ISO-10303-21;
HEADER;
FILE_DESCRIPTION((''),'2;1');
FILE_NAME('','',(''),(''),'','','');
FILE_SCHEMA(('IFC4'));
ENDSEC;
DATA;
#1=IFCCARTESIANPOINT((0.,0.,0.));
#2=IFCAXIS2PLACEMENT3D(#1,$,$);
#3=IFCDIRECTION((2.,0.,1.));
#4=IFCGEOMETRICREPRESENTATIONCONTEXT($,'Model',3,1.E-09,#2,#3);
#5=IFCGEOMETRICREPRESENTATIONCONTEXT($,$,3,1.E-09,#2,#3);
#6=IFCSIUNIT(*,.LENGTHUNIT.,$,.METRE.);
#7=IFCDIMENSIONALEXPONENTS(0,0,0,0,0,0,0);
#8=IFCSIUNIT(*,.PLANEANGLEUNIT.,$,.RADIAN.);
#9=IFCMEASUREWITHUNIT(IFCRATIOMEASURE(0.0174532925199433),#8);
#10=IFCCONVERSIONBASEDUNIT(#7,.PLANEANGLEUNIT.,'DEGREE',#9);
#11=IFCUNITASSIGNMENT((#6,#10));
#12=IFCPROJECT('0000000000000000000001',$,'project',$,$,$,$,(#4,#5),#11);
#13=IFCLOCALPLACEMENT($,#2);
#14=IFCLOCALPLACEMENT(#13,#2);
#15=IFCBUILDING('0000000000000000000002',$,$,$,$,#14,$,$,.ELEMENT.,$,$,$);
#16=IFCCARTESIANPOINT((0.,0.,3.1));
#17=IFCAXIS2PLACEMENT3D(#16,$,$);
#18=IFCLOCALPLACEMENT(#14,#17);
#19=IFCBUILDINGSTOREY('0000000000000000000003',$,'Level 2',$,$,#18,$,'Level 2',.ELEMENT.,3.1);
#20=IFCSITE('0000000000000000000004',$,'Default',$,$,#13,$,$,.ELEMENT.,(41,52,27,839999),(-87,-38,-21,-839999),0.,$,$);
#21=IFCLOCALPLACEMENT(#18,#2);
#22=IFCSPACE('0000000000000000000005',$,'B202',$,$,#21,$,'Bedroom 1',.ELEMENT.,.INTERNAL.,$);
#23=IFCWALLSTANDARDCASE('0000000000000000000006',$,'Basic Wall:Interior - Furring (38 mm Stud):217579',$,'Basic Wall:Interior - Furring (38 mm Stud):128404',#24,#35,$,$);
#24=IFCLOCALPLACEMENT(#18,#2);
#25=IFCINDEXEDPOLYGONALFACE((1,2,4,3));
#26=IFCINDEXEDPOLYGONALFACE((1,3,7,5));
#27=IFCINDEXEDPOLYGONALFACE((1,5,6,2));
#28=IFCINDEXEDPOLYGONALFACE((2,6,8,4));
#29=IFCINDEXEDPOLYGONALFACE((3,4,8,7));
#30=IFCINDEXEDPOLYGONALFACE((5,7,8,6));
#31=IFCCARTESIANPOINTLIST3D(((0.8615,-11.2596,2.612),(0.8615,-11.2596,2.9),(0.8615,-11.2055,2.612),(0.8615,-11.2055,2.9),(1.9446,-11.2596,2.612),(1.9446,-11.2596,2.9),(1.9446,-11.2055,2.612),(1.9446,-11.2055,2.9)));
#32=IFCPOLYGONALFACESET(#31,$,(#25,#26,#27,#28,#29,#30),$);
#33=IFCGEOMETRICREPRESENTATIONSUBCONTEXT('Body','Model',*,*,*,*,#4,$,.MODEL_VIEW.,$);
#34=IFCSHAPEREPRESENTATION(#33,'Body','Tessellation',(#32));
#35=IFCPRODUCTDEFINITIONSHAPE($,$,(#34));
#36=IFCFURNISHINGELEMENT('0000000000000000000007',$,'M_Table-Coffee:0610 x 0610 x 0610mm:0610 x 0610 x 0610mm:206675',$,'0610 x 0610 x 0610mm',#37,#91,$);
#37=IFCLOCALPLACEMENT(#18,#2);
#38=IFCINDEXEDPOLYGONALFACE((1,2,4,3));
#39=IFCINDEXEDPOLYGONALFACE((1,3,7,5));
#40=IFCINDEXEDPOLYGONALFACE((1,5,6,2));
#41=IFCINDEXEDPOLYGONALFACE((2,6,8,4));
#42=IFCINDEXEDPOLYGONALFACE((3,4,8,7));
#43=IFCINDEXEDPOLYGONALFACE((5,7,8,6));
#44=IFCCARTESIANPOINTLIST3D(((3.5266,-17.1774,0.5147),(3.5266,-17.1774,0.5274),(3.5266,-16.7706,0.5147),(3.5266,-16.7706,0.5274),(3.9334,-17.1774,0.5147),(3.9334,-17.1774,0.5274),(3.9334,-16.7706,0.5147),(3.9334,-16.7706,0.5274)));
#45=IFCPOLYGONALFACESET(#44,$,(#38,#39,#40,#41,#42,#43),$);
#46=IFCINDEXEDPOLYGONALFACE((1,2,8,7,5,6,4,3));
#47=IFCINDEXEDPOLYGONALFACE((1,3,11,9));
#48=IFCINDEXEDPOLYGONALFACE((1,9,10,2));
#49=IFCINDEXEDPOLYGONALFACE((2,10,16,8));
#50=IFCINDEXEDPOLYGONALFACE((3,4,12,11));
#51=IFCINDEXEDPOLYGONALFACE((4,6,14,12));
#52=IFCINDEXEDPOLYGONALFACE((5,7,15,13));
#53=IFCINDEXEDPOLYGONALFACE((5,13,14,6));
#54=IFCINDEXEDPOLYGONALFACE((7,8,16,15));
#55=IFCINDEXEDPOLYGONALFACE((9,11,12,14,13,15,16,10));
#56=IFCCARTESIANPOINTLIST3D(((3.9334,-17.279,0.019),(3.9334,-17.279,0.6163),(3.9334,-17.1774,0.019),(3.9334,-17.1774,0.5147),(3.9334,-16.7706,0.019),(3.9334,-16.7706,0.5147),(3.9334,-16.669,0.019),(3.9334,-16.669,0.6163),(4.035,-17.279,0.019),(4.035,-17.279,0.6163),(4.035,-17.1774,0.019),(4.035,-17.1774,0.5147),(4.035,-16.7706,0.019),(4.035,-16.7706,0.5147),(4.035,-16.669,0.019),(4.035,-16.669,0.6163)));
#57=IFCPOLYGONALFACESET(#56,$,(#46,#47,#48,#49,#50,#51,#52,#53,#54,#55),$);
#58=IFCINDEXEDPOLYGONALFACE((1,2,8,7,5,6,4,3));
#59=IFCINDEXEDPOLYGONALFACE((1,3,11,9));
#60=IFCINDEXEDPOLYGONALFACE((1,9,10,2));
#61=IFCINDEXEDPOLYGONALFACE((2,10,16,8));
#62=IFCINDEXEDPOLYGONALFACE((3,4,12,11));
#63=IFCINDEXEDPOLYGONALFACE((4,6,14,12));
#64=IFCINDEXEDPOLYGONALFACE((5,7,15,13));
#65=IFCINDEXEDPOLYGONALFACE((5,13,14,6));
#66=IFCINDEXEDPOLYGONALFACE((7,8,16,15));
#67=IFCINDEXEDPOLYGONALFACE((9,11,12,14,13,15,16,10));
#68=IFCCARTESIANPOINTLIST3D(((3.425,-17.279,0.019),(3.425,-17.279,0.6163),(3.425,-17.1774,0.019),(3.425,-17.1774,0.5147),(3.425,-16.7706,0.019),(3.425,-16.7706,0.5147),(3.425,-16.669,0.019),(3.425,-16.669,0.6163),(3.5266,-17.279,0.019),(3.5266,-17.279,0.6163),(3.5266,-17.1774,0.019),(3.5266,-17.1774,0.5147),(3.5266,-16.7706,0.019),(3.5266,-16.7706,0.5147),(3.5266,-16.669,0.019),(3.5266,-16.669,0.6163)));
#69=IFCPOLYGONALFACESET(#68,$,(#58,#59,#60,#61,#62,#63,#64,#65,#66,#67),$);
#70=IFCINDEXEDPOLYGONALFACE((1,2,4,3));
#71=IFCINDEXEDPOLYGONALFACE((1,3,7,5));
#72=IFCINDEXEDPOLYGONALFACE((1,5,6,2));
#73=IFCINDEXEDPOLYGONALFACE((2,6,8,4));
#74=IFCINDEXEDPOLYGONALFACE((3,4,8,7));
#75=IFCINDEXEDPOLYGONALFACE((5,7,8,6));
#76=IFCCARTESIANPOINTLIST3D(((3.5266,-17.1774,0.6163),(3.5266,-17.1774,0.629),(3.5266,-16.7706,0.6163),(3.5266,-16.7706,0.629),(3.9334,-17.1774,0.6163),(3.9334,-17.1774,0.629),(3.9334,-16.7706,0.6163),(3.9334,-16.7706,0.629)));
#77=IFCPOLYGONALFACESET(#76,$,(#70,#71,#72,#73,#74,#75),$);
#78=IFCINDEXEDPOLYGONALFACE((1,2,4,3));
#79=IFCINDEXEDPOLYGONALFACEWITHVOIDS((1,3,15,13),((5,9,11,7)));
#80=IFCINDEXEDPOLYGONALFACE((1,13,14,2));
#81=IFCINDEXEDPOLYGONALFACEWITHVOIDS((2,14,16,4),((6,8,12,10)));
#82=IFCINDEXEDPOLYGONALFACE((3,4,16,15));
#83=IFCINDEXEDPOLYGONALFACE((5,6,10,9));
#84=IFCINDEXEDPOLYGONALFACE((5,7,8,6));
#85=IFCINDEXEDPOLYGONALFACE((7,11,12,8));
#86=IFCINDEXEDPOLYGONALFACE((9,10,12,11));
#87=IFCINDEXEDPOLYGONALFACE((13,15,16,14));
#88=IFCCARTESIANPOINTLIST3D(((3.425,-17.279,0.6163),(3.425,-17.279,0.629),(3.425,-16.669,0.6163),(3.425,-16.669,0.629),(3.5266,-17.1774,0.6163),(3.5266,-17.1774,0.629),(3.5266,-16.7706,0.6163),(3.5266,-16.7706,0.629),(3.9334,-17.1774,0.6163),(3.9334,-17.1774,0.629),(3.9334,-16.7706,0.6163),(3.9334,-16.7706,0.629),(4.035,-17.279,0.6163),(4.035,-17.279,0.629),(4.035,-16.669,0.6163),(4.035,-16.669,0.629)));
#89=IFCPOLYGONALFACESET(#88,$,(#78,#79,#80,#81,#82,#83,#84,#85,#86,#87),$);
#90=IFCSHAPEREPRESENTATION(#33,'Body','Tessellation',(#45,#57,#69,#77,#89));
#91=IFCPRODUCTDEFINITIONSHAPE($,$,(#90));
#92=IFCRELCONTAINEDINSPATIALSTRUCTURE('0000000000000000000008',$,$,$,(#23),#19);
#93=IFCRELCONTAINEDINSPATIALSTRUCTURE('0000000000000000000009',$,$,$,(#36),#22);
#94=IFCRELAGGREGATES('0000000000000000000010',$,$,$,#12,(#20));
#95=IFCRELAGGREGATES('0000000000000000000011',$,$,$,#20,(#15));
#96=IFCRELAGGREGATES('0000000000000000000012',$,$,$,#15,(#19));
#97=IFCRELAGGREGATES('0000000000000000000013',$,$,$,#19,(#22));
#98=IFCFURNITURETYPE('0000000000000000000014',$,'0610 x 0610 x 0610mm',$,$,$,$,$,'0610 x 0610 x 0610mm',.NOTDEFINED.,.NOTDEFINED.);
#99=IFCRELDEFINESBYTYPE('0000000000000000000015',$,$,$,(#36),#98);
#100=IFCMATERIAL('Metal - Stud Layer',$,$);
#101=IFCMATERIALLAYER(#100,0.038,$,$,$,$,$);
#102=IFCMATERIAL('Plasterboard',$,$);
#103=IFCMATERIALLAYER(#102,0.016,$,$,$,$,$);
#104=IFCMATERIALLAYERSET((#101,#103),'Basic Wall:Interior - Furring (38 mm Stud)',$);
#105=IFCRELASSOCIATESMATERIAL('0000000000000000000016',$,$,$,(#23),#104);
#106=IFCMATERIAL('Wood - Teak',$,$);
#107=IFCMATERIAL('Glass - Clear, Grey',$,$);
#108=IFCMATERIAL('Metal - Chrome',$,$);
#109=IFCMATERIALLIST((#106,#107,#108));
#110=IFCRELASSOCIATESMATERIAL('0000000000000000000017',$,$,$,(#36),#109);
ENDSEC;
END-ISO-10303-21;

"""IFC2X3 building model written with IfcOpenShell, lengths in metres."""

from ifc_helpers import new_model, entity, si_unit, converted_unit, direction, frame, frame_2d, origin, origin_2d_with_axis, place, context, subcontext, project, spatial, polyline, rectangle, outline, extrude, source, transform, mapped, material, material_list, layer, layer_set, layer_usage, type_object, type_shapes, element, save


model = new_model("IFC2X3")

# Units and contexts
model_context = context("Model", 3, precision=1e-09, world=origin(), true_north=direction((2.0, 0.0, 1.0)))
context_of_model = context(None, 3, precision=1e-09, world=origin(), true_north=direction((2.0, 0.0, 1.0)))
body_context = subcontext(model_context, "Body", "Model", "MODEL_VIEW")
ifc_project = project(units=[si_unit("LENGTHUNIT", "METRE"), converted_unit("PLANEANGLEUNIT", "DEGREE", entity("IfcRatioMeasure", 0.0174532925199433), si_unit("PLANEANGLEUNIT", "RADIAN"), dimensions=[0, 0, 0, 0, 0, 0, 0])], contexts=[model_context, context_of_model])

# Site, building, storey
site_placement = place(None, origin())
site = spatial("IfcSite", under=ifc_project, at=site_placement, Name="Default", CompositionType="ELEMENT", RefLatitude=(41, 52, 27, 839999), RefLongitude=(-87, -38, -21, -839999), RefElevation=0.0)
building_placement = place(site_placement, origin())
building = spatial("IfcBuilding", under=site, at=building_placement, CompositionType="ELEMENT")
storey_placement = place(building_placement, frame((0.0, 0.0, 3.1)))
storey = spatial("IfcBuildingStorey", under=building, at=storey_placement, Name="Level 2", LongName="Level 2", CompositionType="ELEMENT", Elevation=3.1)

# Shared definitions
ifc_material_1 = material(Name="Metal - Stud Layer")
ifc_material_2 = material(Name="Plasterboard")

# Wall
ifc_layer_1 = layer(ifc_material_1, 0.038)
ifc_layer_2 = layer(ifc_material_2, 0.016)
ifc_layer_set_1 = layer_set([ifc_layer_1, ifc_layer_2], Name="Basic Wall:Interior - Furring (38 mm Stud)")
ifc_layer_usage_1 = layer_usage(ifc_layer_set_1, "AXIS2", "NEGATIVE", 0.027)
wall_1_placement = place(storey_placement, frame((1.9446, -11.2325, 2.612), z_axis=(0.0, 0.0, 1.0), x_axis=(-1.0, 0.0, 0.0)))
element("IfcWallStandardCase", 1, at=wall_1_placement, inside=storey, material=ifc_layer_usage_1, Name="Basic Wall:Interior - Furring (38 mm Stud):217579", ObjectType="Basic Wall:Interior - Furring (38 mm Stud):128404", context=body_context, shape_type="SweptSolid", body=[
    extrude(rectangle(XDim=1.0831, YDim=0.054, at=frame_2d((0.5415, 0.0), x_axis=(-1.0, 0.0))), origin(), (0.0, 0.0, 1.0), 0.288),
])

# Shared definitions
space_placement = place(storey_placement, origin())
space = spatial("IfcSpace", under=storey, at=space_placement, Name="B202", LongName="Bedroom 1", CompositionType="ELEMENT", InteriorOrExteriorSpace="INTERNAL")

# Furnishing element
ifc_material_3 = material(Name="Wood - Teak")
ifc_material_4 = material(Name="Glass - Clear, Grey")
ifc_material_5 = material(Name="Metal - Chrome")
ifc_material_list_1 = material_list([ifc_material_3, ifc_material_4, ifc_material_5])
furniture_type_1 = type_object("IfcFurnitureType", Name="0610 x 0610 x 0610mm", ElementType="0610 x 0610 x 0610mm", AssemblyPlace="NOTDEFINED")
shared_shape_1 = source(origin(), body_context, "Body", "SweptSolid", [
    extrude(rectangle(XDim=0.4068, YDim=0.4068, at=origin_2d_with_axis()), frame((0.0183, 0.0952, 0.4957), z_axis=(0.0, 0.0, 1.0), x_axis=(-1.0, 0.0, 0.0)), (0.0, 0.0, 1.0), 0.0127),
    extrude(outline(polyline([(-0.2732, -0.305), (0.324, -0.305), (0.324, 0.305), (-0.2732, 0.305), (-0.2732, 0.2034), (0.2225, 0.2034), (0.2225, -0.2034), (-0.2732, -0.2034), (-0.2732, -0.305)])), frame((0.2217, 0.0952, 0.2732), z_axis=(1.0, 0.0, 0.0), x_axis=(0.0, 0.0, 1.0)), (0.0, 0.0, 1.0), 0.1016),
    extrude(outline(polyline([(-0.305, -0.3241), (0.305, -0.3241), (0.305, 0.2733), (0.2034, 0.2733), (0.2034, -0.2224), (-0.2034, -0.2224), (-0.2034, 0.2733), (-0.305, 0.2733), (-0.305, -0.3241)])), frame((-0.2867, 0.0952, 0.2733), z_axis=(1.0, 0.0, 0.0), x_axis=(0.0, -1.0, 0.0)), (0.0, 0.0, 1.0), 0.1016),
    extrude(rectangle(XDim=0.4068, YDim=0.4068, at=origin_2d_with_axis()), frame((0.0183, 0.0952, 0.5973), z_axis=(0.0, 0.0, 1.0), x_axis=(-1.0, 0.0, 0.0)), (0.0, 0.0, 1.0), 0.0127),
    extrude(outline(polyline([(-0.305, -0.305), (0.305, -0.305), (0.305, 0.305), (-0.305, 0.305), (-0.305, -0.305)]), holes=[polyline([(-0.2034, -0.2034), (-0.2034, 0.2034), (0.2034, 0.2034), (0.2034, -0.2034), (-0.2034, -0.2034)])]), frame((0.0183, 0.0952, 0.5973), z_axis=(0.0, 0.0, 1.0), x_axis=(-1.0, 0.0, 0.0)), (0.0, 0.0, 1.0), 0.0127),
])
type_shapes(furniture_type_1, [shared_shape_1])
furnishing_1_placement = place(space_placement, frame((3.7117, -17.0692, 0.019)))
element("IfcFurnishingElement", 2, at=furnishing_1_placement, inside=space, type_object=furniture_type_1, material=ifc_material_list_1, Name="M_Table-Coffee:0610 x 0610 x 0610mm:0610 x 0610 x 0610mm:206675", ObjectType="0610 x 0610 x 0610mm", context=body_context, shape_type="MappedRepresentation", body=[
    mapped(shared_shape_1, transform((0.0, 0.0, 0.0), scale=1.0)),
])

save(model, "model.ifc")
